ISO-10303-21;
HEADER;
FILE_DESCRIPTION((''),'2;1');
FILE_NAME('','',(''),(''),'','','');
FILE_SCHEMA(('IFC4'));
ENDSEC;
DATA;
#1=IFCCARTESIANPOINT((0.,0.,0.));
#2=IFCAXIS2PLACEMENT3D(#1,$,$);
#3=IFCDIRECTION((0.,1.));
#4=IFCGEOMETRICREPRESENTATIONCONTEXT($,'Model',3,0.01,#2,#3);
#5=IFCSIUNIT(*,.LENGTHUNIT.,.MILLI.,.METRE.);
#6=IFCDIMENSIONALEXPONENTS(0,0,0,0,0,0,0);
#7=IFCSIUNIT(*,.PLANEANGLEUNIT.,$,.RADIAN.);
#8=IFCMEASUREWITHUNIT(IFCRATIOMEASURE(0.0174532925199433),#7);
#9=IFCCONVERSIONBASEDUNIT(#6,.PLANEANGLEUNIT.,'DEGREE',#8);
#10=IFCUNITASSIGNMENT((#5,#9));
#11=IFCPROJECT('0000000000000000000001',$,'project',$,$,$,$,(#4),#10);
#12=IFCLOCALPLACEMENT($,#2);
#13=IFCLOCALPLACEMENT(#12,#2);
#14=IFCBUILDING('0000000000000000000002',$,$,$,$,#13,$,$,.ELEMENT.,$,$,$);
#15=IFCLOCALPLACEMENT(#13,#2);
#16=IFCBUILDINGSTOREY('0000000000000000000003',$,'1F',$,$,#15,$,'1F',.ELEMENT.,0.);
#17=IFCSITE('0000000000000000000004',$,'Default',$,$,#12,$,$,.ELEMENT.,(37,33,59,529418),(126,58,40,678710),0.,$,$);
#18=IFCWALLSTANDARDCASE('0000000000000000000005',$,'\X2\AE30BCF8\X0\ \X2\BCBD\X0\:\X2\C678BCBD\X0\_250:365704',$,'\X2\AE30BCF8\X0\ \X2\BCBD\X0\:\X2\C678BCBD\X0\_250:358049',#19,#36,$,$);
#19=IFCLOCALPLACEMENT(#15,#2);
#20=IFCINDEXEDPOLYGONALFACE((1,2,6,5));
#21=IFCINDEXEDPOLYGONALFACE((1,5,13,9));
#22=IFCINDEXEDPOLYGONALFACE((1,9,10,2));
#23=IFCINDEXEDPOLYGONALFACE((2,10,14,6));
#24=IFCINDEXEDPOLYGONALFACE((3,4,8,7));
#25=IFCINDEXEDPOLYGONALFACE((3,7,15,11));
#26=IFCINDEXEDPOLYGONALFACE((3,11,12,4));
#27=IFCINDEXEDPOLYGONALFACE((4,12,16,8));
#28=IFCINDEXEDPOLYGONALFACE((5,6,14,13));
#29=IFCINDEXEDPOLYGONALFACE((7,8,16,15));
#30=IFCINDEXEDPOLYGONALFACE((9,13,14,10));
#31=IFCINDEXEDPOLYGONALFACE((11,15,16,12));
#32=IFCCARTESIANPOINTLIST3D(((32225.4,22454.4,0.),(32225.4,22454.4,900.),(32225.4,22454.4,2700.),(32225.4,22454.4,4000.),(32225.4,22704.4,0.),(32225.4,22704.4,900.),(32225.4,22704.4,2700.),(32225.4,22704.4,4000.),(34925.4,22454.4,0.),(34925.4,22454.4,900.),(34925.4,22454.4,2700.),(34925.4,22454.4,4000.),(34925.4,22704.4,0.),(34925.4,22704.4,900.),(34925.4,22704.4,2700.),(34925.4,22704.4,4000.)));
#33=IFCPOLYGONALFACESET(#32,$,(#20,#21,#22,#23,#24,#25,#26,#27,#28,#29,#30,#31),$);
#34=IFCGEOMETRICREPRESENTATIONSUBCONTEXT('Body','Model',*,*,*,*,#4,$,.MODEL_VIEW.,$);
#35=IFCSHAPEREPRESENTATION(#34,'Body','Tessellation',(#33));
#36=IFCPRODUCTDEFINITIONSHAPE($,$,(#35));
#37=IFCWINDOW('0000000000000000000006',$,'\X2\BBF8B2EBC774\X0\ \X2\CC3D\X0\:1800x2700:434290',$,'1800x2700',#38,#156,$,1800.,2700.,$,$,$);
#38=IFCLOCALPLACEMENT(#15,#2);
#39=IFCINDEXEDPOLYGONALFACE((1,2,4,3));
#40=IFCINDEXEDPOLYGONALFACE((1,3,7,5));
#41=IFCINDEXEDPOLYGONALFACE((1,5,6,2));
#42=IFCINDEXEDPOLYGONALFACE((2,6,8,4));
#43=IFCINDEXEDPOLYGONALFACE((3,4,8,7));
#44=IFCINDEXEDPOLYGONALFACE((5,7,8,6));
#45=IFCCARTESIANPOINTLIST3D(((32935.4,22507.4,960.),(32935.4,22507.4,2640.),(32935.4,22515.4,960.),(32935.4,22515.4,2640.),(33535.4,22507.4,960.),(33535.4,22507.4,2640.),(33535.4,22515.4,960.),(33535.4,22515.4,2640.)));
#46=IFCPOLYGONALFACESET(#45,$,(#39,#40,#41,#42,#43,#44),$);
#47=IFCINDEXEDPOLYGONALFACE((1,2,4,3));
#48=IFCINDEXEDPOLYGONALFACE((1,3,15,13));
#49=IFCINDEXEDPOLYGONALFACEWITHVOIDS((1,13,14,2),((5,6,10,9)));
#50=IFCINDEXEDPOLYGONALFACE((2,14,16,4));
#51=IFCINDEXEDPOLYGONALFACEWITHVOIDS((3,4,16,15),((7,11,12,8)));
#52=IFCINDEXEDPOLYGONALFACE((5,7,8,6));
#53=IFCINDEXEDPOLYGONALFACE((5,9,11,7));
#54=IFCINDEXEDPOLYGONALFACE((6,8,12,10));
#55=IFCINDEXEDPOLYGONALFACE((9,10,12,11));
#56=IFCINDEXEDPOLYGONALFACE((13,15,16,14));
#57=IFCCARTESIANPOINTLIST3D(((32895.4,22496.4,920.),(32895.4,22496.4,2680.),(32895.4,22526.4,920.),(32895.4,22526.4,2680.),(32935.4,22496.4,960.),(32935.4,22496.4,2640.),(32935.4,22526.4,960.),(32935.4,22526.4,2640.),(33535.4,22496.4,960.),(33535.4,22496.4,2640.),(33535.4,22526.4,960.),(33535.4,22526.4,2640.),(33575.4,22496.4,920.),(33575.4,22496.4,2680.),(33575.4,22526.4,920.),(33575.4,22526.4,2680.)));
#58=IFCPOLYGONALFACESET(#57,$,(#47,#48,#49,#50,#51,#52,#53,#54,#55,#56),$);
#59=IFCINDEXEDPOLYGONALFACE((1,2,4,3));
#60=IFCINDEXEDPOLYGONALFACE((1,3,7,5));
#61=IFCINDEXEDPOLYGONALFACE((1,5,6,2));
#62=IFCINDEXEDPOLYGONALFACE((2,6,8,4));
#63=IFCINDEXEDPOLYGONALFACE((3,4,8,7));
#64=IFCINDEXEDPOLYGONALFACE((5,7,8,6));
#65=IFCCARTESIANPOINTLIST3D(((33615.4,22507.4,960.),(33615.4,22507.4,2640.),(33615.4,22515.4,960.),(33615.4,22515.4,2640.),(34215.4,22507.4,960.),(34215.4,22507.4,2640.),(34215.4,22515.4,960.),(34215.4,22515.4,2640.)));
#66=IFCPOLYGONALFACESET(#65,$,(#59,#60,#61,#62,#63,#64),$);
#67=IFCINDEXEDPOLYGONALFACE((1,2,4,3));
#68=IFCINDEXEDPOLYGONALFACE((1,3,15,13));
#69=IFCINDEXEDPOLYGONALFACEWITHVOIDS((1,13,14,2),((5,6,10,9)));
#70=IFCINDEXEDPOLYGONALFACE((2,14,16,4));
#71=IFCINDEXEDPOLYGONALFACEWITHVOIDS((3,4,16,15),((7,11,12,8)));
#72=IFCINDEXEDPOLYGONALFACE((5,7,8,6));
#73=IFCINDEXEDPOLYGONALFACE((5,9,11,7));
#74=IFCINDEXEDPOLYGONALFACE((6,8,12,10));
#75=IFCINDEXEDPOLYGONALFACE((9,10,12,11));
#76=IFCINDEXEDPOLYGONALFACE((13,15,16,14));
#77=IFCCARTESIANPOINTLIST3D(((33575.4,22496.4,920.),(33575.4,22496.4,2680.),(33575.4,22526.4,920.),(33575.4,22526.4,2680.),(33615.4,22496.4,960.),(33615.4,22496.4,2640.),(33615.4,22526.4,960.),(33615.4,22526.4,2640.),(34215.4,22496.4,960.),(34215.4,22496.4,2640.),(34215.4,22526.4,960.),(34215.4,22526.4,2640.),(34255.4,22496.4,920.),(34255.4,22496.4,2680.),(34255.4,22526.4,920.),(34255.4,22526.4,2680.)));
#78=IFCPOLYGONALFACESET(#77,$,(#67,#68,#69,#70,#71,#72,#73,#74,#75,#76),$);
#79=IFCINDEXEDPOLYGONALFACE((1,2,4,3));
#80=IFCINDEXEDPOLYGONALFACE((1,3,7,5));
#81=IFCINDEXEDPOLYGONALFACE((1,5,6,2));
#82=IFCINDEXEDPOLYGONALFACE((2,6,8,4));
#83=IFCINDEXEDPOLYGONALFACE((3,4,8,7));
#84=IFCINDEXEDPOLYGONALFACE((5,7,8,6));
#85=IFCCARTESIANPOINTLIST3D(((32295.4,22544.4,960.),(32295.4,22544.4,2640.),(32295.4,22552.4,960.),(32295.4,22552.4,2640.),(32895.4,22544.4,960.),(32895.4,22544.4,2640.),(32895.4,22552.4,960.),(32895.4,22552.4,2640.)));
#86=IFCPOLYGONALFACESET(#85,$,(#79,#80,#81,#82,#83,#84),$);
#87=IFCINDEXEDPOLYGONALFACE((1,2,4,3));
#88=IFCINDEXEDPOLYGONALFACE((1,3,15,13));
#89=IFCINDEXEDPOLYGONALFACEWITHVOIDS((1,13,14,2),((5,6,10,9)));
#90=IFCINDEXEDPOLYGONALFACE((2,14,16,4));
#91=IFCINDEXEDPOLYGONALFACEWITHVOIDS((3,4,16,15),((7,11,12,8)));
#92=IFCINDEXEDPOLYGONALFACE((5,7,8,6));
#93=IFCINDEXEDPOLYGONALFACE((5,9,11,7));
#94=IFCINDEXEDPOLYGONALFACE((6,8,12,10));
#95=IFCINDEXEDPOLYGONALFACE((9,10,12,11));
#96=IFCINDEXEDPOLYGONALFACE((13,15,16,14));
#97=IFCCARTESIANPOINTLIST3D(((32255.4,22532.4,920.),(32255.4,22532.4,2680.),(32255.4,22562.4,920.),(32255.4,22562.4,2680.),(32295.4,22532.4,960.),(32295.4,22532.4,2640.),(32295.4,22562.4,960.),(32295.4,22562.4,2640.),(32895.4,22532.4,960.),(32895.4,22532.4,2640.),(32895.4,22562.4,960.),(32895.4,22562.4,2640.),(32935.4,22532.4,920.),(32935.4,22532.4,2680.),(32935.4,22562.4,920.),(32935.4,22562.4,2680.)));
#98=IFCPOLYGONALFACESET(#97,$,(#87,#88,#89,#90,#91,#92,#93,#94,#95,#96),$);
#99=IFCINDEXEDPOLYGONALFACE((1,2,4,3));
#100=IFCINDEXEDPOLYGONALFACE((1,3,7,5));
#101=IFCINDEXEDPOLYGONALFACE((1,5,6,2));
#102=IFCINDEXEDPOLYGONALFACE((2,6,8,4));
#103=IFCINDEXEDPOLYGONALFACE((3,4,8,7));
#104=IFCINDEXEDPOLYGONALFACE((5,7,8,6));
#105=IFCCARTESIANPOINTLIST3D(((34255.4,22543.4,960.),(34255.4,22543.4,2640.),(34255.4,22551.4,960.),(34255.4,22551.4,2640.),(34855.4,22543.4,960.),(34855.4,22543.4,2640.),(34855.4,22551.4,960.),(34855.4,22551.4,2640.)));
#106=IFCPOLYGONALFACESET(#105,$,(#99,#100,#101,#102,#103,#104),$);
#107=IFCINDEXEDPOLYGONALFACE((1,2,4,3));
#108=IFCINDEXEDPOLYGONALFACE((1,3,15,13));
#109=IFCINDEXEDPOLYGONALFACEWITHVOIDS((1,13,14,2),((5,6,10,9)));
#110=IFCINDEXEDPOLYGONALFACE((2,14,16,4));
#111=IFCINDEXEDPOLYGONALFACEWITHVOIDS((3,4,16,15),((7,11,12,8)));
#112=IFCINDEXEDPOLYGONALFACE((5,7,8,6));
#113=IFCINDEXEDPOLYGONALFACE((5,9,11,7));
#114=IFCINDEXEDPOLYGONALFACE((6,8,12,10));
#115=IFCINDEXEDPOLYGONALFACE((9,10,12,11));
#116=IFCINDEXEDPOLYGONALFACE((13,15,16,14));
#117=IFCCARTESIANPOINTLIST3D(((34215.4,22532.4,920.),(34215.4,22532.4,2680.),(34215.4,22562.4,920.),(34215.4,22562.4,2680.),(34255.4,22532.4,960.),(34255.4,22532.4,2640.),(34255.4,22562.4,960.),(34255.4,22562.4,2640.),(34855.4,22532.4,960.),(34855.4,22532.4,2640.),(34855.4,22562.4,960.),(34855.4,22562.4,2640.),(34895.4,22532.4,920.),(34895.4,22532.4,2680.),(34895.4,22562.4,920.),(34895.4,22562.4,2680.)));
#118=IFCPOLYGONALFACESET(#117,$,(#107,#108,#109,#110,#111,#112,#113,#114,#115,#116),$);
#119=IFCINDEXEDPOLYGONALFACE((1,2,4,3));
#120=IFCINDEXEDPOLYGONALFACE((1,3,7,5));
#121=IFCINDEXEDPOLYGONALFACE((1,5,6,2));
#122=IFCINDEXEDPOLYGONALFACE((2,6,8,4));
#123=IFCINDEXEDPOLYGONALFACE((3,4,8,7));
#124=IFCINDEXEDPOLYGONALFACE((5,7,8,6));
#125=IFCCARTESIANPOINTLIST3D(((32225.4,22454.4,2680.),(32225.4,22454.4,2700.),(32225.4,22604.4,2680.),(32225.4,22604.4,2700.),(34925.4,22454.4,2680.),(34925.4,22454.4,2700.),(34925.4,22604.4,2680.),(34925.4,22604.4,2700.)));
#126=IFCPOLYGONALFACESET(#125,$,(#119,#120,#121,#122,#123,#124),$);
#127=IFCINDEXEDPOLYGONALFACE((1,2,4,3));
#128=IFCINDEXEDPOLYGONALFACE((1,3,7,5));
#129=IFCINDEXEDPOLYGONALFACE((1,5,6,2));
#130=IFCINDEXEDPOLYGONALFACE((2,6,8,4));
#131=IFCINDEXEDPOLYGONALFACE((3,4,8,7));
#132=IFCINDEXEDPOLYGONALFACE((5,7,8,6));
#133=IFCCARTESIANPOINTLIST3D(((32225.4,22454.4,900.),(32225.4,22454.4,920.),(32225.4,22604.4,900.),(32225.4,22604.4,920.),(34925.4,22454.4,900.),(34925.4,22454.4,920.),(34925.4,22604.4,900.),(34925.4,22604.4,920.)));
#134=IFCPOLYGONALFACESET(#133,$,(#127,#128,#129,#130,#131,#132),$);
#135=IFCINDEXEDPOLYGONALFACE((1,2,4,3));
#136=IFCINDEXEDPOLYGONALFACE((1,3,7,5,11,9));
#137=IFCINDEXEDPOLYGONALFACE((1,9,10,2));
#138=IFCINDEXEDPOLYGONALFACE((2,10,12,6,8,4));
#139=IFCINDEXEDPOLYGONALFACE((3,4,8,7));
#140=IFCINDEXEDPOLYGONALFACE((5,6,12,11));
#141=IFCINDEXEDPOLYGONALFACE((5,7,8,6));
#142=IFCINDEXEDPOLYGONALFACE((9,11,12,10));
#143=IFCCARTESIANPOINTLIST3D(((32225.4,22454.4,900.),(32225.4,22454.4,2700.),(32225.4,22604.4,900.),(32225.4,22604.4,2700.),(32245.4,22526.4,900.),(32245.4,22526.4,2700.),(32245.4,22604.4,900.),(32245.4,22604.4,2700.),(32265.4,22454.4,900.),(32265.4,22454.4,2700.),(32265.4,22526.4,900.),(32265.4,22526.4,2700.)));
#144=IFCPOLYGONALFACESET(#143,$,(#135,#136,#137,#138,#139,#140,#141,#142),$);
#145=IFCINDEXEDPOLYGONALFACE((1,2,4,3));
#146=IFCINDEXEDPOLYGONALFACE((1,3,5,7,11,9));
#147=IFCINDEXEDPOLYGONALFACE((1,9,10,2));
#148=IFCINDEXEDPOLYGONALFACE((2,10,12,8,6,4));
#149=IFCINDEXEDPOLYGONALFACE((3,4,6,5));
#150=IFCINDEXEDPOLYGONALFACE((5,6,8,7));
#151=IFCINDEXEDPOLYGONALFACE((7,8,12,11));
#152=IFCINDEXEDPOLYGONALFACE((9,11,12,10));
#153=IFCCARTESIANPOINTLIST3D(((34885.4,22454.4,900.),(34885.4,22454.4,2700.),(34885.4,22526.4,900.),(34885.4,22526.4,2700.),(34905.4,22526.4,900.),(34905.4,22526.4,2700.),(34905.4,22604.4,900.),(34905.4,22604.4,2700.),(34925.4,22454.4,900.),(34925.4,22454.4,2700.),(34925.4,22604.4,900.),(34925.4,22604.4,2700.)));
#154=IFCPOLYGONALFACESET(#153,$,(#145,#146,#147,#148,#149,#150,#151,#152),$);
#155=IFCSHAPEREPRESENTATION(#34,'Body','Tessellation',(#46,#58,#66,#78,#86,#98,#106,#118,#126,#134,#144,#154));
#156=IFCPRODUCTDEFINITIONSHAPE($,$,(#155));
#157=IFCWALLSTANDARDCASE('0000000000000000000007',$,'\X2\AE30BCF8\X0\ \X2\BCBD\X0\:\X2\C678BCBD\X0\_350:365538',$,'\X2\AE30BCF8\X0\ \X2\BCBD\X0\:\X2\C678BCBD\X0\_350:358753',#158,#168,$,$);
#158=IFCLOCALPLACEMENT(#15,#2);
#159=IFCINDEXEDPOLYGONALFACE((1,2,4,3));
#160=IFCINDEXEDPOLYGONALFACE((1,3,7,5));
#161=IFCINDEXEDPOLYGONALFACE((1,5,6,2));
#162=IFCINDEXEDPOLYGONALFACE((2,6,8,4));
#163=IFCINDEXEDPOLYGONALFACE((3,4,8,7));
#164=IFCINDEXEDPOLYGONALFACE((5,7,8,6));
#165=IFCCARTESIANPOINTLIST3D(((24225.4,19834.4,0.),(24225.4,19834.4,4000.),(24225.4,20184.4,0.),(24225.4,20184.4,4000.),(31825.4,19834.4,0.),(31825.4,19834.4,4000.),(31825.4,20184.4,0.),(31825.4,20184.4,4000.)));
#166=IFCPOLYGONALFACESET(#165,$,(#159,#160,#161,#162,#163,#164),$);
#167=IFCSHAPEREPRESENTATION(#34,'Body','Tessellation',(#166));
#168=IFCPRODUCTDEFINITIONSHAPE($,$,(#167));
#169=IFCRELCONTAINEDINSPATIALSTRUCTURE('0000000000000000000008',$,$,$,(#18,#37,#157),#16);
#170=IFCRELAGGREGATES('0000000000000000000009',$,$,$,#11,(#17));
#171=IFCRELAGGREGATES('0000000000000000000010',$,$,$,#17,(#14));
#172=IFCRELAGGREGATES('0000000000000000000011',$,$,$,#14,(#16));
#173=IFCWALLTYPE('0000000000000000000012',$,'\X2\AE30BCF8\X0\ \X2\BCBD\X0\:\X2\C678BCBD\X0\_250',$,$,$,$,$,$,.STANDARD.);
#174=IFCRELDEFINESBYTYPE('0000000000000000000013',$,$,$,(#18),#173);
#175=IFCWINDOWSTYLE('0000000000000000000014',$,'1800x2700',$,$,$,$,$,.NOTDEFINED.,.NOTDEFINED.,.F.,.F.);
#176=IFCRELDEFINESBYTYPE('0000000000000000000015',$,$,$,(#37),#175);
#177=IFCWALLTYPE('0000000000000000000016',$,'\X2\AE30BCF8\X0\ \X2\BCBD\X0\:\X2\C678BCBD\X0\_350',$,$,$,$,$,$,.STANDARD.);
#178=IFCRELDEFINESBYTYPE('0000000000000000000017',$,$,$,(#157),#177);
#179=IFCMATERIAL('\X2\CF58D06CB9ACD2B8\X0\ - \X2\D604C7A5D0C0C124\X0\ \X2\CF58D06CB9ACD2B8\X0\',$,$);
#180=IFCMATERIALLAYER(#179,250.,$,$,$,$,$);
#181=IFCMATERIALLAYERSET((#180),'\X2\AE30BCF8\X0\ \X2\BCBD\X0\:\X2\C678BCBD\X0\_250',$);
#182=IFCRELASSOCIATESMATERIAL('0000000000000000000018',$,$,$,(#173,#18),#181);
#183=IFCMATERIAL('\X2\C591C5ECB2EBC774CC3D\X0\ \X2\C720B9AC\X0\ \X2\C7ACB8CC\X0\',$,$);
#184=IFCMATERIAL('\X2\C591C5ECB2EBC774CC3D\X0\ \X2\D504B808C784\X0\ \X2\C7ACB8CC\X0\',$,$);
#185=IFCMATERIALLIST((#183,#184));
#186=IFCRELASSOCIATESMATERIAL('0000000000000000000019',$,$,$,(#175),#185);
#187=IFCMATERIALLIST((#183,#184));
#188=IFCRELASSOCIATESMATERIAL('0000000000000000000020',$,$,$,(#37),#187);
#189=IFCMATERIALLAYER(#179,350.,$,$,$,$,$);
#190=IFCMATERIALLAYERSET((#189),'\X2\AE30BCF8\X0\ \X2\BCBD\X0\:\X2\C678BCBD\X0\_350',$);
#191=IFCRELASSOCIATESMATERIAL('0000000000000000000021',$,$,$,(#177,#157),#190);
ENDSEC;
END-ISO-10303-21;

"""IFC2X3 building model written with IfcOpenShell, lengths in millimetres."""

from ifc_helpers import new_model, entity, si_unit, converted_unit, direction, frame, frame_2d, origin, origin_2d_with_axis, place, context, subcontext, project, spatial, polyline, rectangle, outline, extrude, source, transform, mapped, material, material_list, layer, layer_set, layer_usage, type_object, type_shapes, element, fill, save


model = new_model("IFC2X3")

# Units and contexts
model_context = context("Model", 3, precision=0.01, world=origin(), true_north=direction((0.0, 1.0)))
body_context = subcontext(model_context, "Body", "Model", "MODEL_VIEW")
ifc_project = project(units=[si_unit("LENGTHUNIT", "METRE", prefix="MILLI"), converted_unit("PLANEANGLEUNIT", "DEGREE", entity("IfcRatioMeasure", 0.0174532925199433), si_unit("PLANEANGLEUNIT", "RADIAN"), dimensions=[0, 0, 0, 0, 0, 0, 0])], contexts=[model_context])

# Site, building, storey
site_placement = place(None, origin())
site = spatial("IfcSite", under=ifc_project, at=site_placement, Name="Default", CompositionType="ELEMENT", RefLatitude=(37, 33, 59, 529418), RefLongitude=(126, 58, 40, 678710), RefElevation=0.0)
building_placement = place(site_placement, origin())
building = spatial("IfcBuilding", under=site, at=building_placement, CompositionType="ELEMENT")
storey_placement = place(building_placement, origin())
storey = spatial("IfcBuildingStorey", under=building, at=storey_placement, Name="1F", LongName="1F", CompositionType="ELEMENT", Elevation=0.0)

# Shared definitions
ifc_material_1 = material(Name="콘크리트 - 현장타설 콘크리트")

# Wall, opening, window
ifc_material_2 = material(Name="양여닫이창 유리 재료")
ifc_material_3 = material(Name="양여닫이창 프레임 재료")
ifc_layer_1 = layer(ifc_material_1, 250.0)
ifc_layer_set_1 = layer_set([ifc_layer_1], Name="기본 벽:외벽_250")
ifc_layer_usage_1 = layer_usage(ifc_layer_set_1, "AXIS2", "NEGATIVE", 125.0)
wall_type_1 = type_object("IfcWallType", Name="기본 벽:외벽_250", PredefinedType="STANDARD", material=ifc_layer_set_1)
wall_1_placement = place(storey_placement, frame((34925.4, 22579.4, 0.0), z_axis=(0.0, 0.0, 1.0), x_axis=(-1.0, 0.0, 0.0)))
wall_1 = element("IfcWallStandardCase", 1, at=wall_1_placement, inside=storey, type_object=wall_type_1, material=ifc_layer_usage_1, Name="기본 벽:외벽_250:365704", ObjectType="기본 벽:외벽_250:358049", context=body_context, shape_type="SweptSolid", body=[
    extrude(rectangle(XDim=2700.0, YDim=250.0, at=frame_2d((1350.0, 0.0), x_axis=(-1.0, 0.0))), origin(), (0.0, 0.0, 1.0), 4000.0),
])
opening_1_placement = place(wall_1_placement, frame((0.0, -125.0, 900.0)))
opening_1 = element("IfcOpeningElement", 2, at=opening_1_placement, cuts=wall_1, ObjectType="Opening", context=body_context, shape_type="SweptSolid", body=[
    extrude(rectangle(XDim=1800.0, YDim=2700.0, at=frame_2d((900.0, 1350.0), x_axis=(1.0, 0.0))), frame((0.0, 0.0, 0.0), z_axis=(0.0, 1.0, 0.0), x_axis=(0.0, 0.0, 1.0)), (0.0, 0.0, 1.0), 250.0),
])
ifc_material_list_1 = material_list([ifc_material_2, ifc_material_3])
ifc_material_list_2 = material_list([ifc_material_2, ifc_material_3])
window_style_1 = type_object("IfcWindowStyle", Name="1800x2700", ConstructionType="NOTDEFINED", OperationType="NOTDEFINED", ParameterTakesPrecedence=False, Sizeable=False, material=ifc_material_list_2)
shared_shape_1 = source(origin(), body_context, "Body", "SweptSolid", [
    extrude(rectangle(XDim=8.0, YDim=600.0, at=frame_2d((0.0, 0.0), x_axis=(1.0, 0.0))), frame((1690.0, 193.0, 60.0), z_axis=(0.0, 0.0, 1.0), x_axis=(0.0, 1.0, 0.0)), (0.0, 0.0, 1.0), 1680.0),
    extrude(outline(polyline([(-880.0, -340.0), (880.0, -340.0), (880.0, 340.0), (-880.0, 340.0), (-880.0, -340.0)]), holes=[polyline([(840.0, -300.0), (-840.0, -300.0), (-840.0, 300.0), (840.0, 300.0), (840.0, -300.0)])]), frame((1690.0, 178.0, 900.0), z_axis=(0.0, 1.0, 0.0), x_axis=(0.0, 0.0, -1.0)), (0.0, 0.0, 1.0), 30.0),
    extrude(rectangle(XDim=8.0, YDim=600.0, at=origin_2d_with_axis()), frame((1010.0, 193.0, 60.0), z_axis=(0.0, 0.0, 1.0), x_axis=(0.0, 1.0, 0.0)), (0.0, 0.0, 1.0), 1680.0),
    extrude(outline(polyline([(-880.0, -340.0), (880.0, -340.0), (880.0, 340.0), (-880.0, 340.0), (-880.0, -340.0)]), holes=[polyline([(840.0, -300.0), (-840.0, -300.0), (-840.0, 300.0), (840.0, 300.0), (840.0, -300.0)])]), frame((1010.0, 178.0, 900.0), z_axis=(0.0, 1.0, 0.0), x_axis=(0.0, 0.0, -1.0)), (0.0, 0.0, 1.0), 30.0),
    extrude(rectangle(XDim=8.0, YDim=600.0, at=frame_2d((0.0, 0.0), x_axis=(1.0, 0.0))), frame((2330.0, 156.0, 60.0), z_axis=(0.0, 0.0, 1.0), x_axis=(0.0, 1.0, 0.0)), (0.0, 0.0, 1.0), 1680.0),
    extrude(outline(polyline([(-880.0, -340.0), (880.0, -340.0), (880.0, 340.0), (-880.0, 340.0), (-880.0, -340.0)]), holes=[polyline([(840.0, -300.0), (-840.0, -300.0), (-840.0, 300.0), (840.0, 300.0), (840.0, -300.0)])]), frame((2330.0, 142.0, 900.0), z_axis=(0.0, 1.0, 0.0), x_axis=(0.0, 0.0, -1.0)), (0.0, 0.0, 1.0), 30.0),
    extrude(rectangle(XDim=8.0, YDim=600.0, at=frame_2d((0.0, 0.0), x_axis=(1.0, 0.0))), frame((370.0, 157.0, 60.0), z_axis=(0.0, 0.0, 1.0), x_axis=(0.0, 1.0, 0.0)), (0.0, 0.0, 1.0), 1680.0),
    extrude(outline(polyline([(-880.0, -340.0), (880.0, -340.0), (880.0, 340.0), (-880.0, 340.0), (-880.0, -340.0)]), holes=[polyline([(840.0, -300.0), (-840.0, -300.0), (-840.0, 300.0), (840.0, 300.0), (840.0, -300.0)])]), frame((370.0, 142.0, 900.0), z_axis=(0.0, 1.0, 0.0), x_axis=(0.0, 0.0, -1.0)), (0.0, 0.0, 1.0), 30.0),
    extrude(rectangle(XDim=2700.0, YDim=150.0, at=origin_2d_with_axis()), frame((1350.0, 175.0, 1780.0), z_axis=(0.0, 0.0, 1.0), x_axis=(-1.0, 0.0, 0.0)), (0.0, 0.0, 1.0), 20.0),
    extrude(rectangle(XDim=2700.0, YDim=150.0, at=origin_2d_with_axis()), frame((1350.0, 175.0, 0.0), z_axis=(0.0, 0.0, 1.0), x_axis=(-1.0, 0.0, 0.0)), (0.0, 0.0, 1.0), 20.0),
    extrude(outline(polyline([(-74.0, -20.0), (-2.0, -20.0), (-2.0, 0.0), (76.0, 0.0), (76.0, 20.0), (-74.0, 20.0), (-74.0, -20.0)])), frame((2680.0, 176.0, 0.0), z_axis=(0.0, 0.0, 1.0), x_axis=(0.0, -1.0, 0.0)), (0.0, 0.0, 1.0), 1800.0),
    extrude(outline(polyline([(-20.0, -74.0), (20.0, -74.0), (20.0, 76.0), (0.0, 76.0), (0.0, -2.0), (-20.0, -2.0), (-20.0, -74.0)])), frame((20.0, 176.0, 0.0), z_axis=(0.0, 0.0, 1.0), x_axis=(-1.0, 0.0, 0.0)), (0.0, 0.0, 1.0), 1800.0),
])
type_shapes(window_style_1, [shared_shape_1])
window_1_placement = place(opening_1_placement, origin())
window_1 = element("IfcWindow", 3, at=window_1_placement, inside=storey, type_object=window_style_1, material=ifc_material_list_1, Name="미닫이 창:1800x2700:434290", ObjectType="1800x2700", OverallHeight=1800.0, OverallWidth=2700.0, context=body_context, shape_type="MappedRepresentation", body=[
    mapped(shared_shape_1, transform((0.0, 0.0, 0.0), scale=1.0)),
])
fill(opening_1, window_1)

# Wall
ifc_layer_2 = layer(ifc_material_1, 350.0)
ifc_layer_set_2 = layer_set([ifc_layer_2], Name="기본 벽:외벽_350")
ifc_layer_usage_2 = layer_usage(ifc_layer_set_2, "AXIS2", "NEGATIVE", 175.0)
wall_type_2 = type_object("IfcWallType", Name="기본 벽:외벽_350", PredefinedType="STANDARD", material=ifc_layer_set_2)
wall_2_placement = place(storey_placement, frame((31825.4, 20009.4, 0.0), z_axis=(0.0, 0.0, 1.0), x_axis=(-1.0, 0.0, 0.0)))
element("IfcWallStandardCase", 4, at=wall_2_placement, inside=storey, type_object=wall_type_2, material=ifc_layer_usage_2, Name="기본 벽:외벽_350:365538", ObjectType="기본 벽:외벽_350:358753", context=body_context, shape_type="SweptSolid", body=[
    extrude(rectangle(XDim=7600.0, YDim=350.0, at=frame_2d((3800.0, 0.0), x_axis=(-1.0, 0.0))), origin(), (0.0, 0.0, 1.0), 4000.0),
])

save(model, "model.ifc")
